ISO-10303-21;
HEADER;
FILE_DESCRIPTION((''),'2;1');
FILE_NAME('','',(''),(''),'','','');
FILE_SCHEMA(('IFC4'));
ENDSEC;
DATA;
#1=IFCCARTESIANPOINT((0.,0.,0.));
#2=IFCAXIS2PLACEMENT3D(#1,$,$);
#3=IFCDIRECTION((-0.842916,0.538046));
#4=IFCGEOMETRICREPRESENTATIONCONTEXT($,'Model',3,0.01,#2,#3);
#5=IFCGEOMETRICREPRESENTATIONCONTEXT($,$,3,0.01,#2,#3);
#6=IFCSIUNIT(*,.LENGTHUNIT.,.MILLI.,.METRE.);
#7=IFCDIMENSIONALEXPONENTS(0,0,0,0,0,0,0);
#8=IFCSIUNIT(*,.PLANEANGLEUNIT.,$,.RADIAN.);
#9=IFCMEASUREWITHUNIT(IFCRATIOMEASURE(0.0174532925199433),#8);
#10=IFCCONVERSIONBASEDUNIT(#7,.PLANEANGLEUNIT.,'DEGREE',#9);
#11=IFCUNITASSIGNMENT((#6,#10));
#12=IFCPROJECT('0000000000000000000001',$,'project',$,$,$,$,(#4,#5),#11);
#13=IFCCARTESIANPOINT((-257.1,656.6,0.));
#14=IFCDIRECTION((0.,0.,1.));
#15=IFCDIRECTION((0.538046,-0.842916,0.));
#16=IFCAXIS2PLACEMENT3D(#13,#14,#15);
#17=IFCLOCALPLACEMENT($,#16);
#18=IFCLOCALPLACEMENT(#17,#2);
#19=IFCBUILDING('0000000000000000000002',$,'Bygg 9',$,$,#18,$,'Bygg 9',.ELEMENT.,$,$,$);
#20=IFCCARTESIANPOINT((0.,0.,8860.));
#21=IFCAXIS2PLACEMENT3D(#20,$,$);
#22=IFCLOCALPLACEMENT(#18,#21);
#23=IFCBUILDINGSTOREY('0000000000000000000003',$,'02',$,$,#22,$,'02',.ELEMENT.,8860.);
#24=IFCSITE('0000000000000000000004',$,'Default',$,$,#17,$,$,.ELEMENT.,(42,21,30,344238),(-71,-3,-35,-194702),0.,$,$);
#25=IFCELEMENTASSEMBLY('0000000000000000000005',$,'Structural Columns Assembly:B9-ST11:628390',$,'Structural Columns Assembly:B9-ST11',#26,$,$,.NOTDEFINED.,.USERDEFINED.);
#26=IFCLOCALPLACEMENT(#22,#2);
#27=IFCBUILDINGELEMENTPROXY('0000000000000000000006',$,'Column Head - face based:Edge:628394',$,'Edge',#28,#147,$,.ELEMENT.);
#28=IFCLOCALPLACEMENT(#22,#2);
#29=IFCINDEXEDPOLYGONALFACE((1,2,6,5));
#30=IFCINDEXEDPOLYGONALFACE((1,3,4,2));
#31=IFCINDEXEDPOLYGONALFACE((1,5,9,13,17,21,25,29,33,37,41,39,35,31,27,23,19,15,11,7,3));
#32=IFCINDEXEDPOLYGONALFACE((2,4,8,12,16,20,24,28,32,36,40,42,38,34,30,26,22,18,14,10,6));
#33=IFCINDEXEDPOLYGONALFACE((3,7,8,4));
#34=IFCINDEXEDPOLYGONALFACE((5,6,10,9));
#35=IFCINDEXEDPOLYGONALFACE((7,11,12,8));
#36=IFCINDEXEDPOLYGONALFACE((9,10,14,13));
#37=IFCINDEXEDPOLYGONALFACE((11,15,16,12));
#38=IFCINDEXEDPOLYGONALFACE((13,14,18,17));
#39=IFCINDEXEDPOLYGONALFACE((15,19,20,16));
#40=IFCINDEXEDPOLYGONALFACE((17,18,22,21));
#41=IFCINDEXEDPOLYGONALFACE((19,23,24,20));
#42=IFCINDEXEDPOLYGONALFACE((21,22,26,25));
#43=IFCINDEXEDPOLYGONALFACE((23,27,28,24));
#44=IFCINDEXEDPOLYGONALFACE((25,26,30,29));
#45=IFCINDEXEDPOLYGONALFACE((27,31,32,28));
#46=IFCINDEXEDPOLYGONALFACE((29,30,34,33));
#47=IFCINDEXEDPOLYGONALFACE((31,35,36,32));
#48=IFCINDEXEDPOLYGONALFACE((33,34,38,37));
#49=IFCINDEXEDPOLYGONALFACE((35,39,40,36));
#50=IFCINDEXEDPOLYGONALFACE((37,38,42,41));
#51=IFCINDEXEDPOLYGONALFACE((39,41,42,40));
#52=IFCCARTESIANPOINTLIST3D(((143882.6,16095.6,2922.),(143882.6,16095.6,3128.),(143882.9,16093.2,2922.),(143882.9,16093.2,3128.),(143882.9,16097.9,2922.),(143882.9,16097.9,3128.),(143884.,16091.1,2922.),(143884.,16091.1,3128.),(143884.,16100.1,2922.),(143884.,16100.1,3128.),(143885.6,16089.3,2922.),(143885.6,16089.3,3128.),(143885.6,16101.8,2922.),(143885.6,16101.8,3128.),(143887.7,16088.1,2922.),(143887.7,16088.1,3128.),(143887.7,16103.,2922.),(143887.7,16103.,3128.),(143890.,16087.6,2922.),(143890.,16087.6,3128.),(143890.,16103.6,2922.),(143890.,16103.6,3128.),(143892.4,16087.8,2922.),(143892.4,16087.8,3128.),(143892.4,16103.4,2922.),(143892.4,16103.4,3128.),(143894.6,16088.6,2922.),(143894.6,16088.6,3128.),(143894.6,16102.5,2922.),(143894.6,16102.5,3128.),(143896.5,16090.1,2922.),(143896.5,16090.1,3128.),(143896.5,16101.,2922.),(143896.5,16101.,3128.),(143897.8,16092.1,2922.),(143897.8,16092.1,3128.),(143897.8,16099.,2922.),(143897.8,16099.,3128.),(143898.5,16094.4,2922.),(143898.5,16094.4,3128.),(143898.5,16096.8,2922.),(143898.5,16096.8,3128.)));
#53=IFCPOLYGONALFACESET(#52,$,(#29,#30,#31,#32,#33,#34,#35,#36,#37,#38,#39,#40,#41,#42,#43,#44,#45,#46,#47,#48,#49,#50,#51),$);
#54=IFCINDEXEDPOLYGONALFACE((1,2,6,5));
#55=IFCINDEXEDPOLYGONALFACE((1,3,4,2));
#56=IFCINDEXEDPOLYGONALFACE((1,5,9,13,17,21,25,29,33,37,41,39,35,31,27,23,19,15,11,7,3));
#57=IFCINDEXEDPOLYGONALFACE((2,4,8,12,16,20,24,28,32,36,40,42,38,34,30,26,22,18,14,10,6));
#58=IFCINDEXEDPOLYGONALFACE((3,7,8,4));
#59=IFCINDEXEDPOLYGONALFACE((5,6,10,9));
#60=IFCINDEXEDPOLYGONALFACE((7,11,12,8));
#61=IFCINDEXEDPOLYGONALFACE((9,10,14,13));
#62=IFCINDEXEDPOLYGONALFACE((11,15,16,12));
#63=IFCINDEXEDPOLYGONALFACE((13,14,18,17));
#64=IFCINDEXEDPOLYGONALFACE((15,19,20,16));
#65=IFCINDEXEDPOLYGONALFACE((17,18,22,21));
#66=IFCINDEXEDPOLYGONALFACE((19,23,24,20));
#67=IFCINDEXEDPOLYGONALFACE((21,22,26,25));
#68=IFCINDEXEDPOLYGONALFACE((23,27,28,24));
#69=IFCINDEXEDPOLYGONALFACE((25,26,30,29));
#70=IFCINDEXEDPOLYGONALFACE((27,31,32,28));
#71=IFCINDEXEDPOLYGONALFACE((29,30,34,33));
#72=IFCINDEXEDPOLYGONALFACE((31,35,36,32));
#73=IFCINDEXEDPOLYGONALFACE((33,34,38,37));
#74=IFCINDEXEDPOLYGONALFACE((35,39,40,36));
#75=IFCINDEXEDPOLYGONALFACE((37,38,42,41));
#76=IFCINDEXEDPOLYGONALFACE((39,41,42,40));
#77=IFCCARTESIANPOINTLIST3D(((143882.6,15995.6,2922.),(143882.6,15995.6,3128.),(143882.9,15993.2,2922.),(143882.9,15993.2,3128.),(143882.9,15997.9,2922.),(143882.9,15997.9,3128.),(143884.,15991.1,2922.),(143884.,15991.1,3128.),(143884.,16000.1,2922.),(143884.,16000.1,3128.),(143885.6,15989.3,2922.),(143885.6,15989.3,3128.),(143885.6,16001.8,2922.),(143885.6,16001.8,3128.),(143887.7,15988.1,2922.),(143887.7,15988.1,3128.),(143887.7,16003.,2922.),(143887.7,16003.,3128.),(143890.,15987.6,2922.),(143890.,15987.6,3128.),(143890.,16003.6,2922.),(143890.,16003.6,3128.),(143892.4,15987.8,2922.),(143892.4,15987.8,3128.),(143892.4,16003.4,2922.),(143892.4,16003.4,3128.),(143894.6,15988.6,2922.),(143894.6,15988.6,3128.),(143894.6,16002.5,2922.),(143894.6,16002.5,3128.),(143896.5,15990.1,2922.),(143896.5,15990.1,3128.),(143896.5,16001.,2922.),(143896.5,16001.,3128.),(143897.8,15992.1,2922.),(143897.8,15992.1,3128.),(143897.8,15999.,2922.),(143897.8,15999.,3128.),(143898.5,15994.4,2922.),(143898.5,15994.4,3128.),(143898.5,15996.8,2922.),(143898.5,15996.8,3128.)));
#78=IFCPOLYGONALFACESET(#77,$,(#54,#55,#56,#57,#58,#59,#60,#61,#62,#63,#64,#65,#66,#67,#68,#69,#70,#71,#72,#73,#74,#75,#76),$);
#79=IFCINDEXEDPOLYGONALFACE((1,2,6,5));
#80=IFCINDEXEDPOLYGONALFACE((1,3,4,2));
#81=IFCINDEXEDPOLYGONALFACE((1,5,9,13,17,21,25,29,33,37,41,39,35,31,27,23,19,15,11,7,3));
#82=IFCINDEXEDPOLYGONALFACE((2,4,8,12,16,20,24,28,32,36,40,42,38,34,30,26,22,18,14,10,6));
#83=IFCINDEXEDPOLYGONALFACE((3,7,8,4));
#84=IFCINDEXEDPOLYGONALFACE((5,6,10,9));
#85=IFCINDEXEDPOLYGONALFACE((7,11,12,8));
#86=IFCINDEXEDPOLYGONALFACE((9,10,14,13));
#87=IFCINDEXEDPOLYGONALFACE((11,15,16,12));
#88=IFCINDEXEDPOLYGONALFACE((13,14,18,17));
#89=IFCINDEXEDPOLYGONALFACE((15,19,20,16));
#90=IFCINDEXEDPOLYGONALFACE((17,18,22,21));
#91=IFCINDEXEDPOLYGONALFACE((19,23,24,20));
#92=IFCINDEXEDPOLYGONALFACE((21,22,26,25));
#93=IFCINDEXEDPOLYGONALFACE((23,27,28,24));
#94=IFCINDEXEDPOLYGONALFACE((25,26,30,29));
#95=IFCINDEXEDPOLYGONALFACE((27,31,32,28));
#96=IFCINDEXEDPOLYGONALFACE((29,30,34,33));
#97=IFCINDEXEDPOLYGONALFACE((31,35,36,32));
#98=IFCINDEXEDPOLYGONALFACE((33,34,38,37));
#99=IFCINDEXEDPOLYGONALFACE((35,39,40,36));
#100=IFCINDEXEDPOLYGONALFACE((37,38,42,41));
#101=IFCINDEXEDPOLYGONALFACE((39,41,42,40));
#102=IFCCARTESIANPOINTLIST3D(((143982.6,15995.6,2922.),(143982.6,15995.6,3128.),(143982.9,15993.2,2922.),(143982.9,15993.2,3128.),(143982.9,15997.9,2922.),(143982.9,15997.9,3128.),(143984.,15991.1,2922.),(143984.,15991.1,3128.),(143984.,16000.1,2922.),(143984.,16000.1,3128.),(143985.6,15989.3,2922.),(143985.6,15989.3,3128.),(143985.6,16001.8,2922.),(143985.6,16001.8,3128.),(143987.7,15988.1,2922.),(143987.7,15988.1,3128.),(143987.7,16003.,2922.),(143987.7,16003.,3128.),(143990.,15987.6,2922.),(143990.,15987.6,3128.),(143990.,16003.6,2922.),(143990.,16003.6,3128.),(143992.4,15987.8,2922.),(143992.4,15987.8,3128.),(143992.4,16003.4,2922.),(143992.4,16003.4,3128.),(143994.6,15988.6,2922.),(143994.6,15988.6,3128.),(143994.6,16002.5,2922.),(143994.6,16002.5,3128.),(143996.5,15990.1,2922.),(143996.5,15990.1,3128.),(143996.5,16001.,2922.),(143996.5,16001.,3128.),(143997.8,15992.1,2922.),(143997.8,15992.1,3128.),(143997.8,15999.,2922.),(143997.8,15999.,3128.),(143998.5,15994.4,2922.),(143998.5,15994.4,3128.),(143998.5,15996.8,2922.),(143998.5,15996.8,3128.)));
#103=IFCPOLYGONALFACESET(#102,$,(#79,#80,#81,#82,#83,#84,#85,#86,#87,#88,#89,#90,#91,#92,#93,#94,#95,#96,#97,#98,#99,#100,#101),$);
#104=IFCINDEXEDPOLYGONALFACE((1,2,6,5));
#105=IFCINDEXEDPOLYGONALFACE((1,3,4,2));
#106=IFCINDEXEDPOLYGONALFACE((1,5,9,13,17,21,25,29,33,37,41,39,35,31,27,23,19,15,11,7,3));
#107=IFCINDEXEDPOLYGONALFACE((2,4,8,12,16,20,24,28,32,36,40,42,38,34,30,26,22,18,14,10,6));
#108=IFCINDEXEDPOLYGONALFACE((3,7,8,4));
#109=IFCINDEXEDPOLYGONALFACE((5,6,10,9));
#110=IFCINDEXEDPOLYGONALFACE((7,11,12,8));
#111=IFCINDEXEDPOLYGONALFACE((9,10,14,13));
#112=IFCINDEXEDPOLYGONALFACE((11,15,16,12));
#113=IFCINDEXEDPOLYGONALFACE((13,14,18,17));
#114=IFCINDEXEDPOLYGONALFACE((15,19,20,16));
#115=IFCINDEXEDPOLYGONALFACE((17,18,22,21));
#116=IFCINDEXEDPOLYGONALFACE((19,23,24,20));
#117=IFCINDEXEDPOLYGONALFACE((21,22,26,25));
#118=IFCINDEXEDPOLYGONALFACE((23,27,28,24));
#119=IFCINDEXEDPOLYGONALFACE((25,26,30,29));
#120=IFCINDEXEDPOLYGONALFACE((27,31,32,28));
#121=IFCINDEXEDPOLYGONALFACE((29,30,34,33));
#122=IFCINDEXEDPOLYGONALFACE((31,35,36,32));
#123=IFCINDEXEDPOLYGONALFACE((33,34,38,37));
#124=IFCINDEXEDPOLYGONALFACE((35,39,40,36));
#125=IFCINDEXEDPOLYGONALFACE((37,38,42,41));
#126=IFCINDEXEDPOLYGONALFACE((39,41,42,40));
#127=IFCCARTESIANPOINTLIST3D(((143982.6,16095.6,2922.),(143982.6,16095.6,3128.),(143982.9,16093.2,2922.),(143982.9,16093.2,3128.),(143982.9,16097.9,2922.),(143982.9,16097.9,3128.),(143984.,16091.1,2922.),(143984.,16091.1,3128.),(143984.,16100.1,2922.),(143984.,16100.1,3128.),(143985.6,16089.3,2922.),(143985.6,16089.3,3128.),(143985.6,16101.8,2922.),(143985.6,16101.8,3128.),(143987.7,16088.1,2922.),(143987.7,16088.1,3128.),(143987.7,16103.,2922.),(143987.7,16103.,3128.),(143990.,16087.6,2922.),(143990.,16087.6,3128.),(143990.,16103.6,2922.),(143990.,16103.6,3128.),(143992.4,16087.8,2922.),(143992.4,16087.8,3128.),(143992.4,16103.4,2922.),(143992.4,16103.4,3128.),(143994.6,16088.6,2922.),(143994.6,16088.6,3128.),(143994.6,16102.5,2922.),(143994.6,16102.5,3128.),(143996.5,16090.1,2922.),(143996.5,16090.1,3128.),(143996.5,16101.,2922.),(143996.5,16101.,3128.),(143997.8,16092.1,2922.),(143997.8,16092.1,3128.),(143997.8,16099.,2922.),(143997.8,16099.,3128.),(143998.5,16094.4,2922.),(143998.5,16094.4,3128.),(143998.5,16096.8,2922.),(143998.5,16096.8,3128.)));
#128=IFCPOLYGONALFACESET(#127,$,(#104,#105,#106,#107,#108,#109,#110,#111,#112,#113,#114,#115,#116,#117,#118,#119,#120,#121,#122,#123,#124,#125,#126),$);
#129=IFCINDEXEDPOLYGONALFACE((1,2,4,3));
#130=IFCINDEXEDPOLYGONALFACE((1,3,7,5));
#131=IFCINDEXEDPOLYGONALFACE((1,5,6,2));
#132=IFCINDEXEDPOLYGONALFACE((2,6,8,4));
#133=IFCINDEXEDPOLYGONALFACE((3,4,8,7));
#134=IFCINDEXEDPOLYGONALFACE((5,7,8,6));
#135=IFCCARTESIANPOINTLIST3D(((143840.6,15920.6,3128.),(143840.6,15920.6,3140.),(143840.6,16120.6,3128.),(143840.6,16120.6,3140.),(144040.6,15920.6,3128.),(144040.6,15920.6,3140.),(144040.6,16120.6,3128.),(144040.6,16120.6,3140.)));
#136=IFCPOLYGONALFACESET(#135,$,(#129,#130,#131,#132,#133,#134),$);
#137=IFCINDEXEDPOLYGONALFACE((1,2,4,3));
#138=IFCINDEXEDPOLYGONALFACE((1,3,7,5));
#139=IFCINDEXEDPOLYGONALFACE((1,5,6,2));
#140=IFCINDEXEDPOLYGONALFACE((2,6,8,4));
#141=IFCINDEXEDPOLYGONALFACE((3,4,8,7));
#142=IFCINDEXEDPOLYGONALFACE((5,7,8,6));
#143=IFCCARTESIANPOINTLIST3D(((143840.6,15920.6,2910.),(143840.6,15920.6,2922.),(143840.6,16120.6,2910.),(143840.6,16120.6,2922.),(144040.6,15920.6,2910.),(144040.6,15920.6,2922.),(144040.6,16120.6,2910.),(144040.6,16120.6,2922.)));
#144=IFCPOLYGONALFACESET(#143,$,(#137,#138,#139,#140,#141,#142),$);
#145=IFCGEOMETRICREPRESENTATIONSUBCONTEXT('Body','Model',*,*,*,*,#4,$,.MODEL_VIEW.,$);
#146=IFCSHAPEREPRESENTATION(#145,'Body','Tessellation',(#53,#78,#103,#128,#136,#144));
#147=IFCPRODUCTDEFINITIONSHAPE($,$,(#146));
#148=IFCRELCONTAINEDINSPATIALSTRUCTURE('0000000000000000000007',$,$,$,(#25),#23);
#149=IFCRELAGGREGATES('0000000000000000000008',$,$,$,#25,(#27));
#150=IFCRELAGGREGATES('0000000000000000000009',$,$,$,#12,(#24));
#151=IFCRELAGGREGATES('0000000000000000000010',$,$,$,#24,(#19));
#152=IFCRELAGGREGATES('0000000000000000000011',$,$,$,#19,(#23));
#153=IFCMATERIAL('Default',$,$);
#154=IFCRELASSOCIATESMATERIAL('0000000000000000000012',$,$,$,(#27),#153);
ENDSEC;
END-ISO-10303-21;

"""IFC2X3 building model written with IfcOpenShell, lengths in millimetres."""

from ifc_helpers import new_model, entity, si_unit, converted_unit, direction, frame, frame_2d, origin, origin_2d_with_axis, place, context, subcontext, project, spatial, rectangle, circle, extrude, source, transform, mapped, material, element, aggregate, save


model = new_model("IFC2X3")

# Units and contexts
model_context = context("Model", 3, precision=0.01, world=origin(), true_north=direction((-0.842916, 0.538046)))
context_of_model = context(None, 3, precision=0.01, world=origin(), true_north=direction((-0.842916, 0.538046)))
body_context = subcontext(model_context, "Body", "Model", "MODEL_VIEW")
ifc_project = project(units=[si_unit("LENGTHUNIT", "METRE", prefix="MILLI"), converted_unit("PLANEANGLEUNIT", "DEGREE", entity("IfcRatioMeasure", 0.0174532925199433), si_unit("PLANEANGLEUNIT", "RADIAN"), dimensions=[0, 0, 0, 0, 0, 0, 0])], contexts=[model_context, context_of_model])

# Site, building, storey
site_placement = place(None, frame((-257.1, 656.6, 0.0), z_axis=(0.0, 0.0, 1.0), x_axis=(0.538046, -0.842916, 0.0)))
site = spatial("IfcSite", under=ifc_project, at=site_placement, Name="Default", CompositionType="ELEMENT", RefLatitude=(42, 21, 30, 344238), RefLongitude=(-71, -3, -35, -194702), RefElevation=0.0)
building_placement = place(site_placement, origin())
building = spatial("IfcBuilding", under=site, at=building_placement, Name="Bygg 9", LongName="Bygg 9", CompositionType="ELEMENT")
storey_placement = place(building_placement, frame((0.0, 0.0, 8860.0)))
storey = spatial("IfcBuildingStorey", under=building, at=storey_placement, Name="02", LongName="02", CompositionType="ELEMENT", Elevation=8860.0)

# Element assembly
assembly_1_placement = place(storey_placement, origin())
assembly_1 = element("IfcElementAssembly", 1, at=assembly_1_placement, inside=storey, Name="Structural Columns Assembly:B9-ST11:628390", ObjectType="Structural Columns Assembly:B9-ST11", AssemblyPlace="NOTDEFINED", PredefinedType="USERDEFINED")

# Building element proxy
ifc_material_1 = material(Name="Default")
shared_shape_1 = source(origin(), body_context, "Body", "SweptSolid", [
    extrude(circle(Radius=8.0, at=frame_2d((0.0, 0.0), x_axis=(1.0, 0.0))), frame((50.0, -75.0, 12.0)), (0.0, 0.0, 1.0), 206.0),
    extrude(circle(Radius=8.0, at=frame_2d((0.0, 0.0), x_axis=(1.0, 0.0))), frame((50.0, 25.0, 12.0)), (0.0, 0.0, 1.0), 206.0),
    extrude(circle(Radius=8.0, at=frame_2d((0.0, 0.0), x_axis=(1.0, 0.0))), frame((-50.0, 25.0, 12.0)), (0.0, 0.0, 1.0), 206.0),
    extrude(circle(Radius=8.0, at=frame_2d((0.0, 0.0), x_axis=(1.0, 0.0))), frame((-50.0, -75.0, 12.0)), (0.0, 0.0, 1.0), 206.0),
    extrude(rectangle(XDim=200.0, YDim=200.0, at=origin_2d_with_axis()), frame((0.0, 0.0, 218.0), z_axis=(0.0, 0.0, 1.0), x_axis=(-1.0, 0.0, 0.0)), (0.0, 0.0, 1.0), 12.0),
    extrude(rectangle(XDim=200.0, YDim=200.0, at=origin_2d_with_axis()), frame((0.0, 0.0, 0.0), z_axis=(0.0, 0.0, 1.0), x_axis=(0.0, 1.0, 0.0)), (0.0, 0.0, 1.0), 12.0),
])
proxy_1_placement = place(assembly_1_placement, frame((143940.6, 16020.6, 2910.0), z_axis=(0.0, 0.0, 1.0), x_axis=(-1.0, 0.0, 0.0)))
proxy_1 = element("IfcBuildingElementProxy", 2, at=proxy_1_placement, material=ifc_material_1, Name="Column Head - face based:Edge:628394", ObjectType="Edge", CompositionType="ELEMENT", context=body_context, shape_type="MappedRepresentation", body=[
    mapped(shared_shape_1, transform((0.0, 0.0, 0.0), scale=1.0)),
])
aggregate(assembly_1, [proxy_1])

save(model, "model.ifc")
